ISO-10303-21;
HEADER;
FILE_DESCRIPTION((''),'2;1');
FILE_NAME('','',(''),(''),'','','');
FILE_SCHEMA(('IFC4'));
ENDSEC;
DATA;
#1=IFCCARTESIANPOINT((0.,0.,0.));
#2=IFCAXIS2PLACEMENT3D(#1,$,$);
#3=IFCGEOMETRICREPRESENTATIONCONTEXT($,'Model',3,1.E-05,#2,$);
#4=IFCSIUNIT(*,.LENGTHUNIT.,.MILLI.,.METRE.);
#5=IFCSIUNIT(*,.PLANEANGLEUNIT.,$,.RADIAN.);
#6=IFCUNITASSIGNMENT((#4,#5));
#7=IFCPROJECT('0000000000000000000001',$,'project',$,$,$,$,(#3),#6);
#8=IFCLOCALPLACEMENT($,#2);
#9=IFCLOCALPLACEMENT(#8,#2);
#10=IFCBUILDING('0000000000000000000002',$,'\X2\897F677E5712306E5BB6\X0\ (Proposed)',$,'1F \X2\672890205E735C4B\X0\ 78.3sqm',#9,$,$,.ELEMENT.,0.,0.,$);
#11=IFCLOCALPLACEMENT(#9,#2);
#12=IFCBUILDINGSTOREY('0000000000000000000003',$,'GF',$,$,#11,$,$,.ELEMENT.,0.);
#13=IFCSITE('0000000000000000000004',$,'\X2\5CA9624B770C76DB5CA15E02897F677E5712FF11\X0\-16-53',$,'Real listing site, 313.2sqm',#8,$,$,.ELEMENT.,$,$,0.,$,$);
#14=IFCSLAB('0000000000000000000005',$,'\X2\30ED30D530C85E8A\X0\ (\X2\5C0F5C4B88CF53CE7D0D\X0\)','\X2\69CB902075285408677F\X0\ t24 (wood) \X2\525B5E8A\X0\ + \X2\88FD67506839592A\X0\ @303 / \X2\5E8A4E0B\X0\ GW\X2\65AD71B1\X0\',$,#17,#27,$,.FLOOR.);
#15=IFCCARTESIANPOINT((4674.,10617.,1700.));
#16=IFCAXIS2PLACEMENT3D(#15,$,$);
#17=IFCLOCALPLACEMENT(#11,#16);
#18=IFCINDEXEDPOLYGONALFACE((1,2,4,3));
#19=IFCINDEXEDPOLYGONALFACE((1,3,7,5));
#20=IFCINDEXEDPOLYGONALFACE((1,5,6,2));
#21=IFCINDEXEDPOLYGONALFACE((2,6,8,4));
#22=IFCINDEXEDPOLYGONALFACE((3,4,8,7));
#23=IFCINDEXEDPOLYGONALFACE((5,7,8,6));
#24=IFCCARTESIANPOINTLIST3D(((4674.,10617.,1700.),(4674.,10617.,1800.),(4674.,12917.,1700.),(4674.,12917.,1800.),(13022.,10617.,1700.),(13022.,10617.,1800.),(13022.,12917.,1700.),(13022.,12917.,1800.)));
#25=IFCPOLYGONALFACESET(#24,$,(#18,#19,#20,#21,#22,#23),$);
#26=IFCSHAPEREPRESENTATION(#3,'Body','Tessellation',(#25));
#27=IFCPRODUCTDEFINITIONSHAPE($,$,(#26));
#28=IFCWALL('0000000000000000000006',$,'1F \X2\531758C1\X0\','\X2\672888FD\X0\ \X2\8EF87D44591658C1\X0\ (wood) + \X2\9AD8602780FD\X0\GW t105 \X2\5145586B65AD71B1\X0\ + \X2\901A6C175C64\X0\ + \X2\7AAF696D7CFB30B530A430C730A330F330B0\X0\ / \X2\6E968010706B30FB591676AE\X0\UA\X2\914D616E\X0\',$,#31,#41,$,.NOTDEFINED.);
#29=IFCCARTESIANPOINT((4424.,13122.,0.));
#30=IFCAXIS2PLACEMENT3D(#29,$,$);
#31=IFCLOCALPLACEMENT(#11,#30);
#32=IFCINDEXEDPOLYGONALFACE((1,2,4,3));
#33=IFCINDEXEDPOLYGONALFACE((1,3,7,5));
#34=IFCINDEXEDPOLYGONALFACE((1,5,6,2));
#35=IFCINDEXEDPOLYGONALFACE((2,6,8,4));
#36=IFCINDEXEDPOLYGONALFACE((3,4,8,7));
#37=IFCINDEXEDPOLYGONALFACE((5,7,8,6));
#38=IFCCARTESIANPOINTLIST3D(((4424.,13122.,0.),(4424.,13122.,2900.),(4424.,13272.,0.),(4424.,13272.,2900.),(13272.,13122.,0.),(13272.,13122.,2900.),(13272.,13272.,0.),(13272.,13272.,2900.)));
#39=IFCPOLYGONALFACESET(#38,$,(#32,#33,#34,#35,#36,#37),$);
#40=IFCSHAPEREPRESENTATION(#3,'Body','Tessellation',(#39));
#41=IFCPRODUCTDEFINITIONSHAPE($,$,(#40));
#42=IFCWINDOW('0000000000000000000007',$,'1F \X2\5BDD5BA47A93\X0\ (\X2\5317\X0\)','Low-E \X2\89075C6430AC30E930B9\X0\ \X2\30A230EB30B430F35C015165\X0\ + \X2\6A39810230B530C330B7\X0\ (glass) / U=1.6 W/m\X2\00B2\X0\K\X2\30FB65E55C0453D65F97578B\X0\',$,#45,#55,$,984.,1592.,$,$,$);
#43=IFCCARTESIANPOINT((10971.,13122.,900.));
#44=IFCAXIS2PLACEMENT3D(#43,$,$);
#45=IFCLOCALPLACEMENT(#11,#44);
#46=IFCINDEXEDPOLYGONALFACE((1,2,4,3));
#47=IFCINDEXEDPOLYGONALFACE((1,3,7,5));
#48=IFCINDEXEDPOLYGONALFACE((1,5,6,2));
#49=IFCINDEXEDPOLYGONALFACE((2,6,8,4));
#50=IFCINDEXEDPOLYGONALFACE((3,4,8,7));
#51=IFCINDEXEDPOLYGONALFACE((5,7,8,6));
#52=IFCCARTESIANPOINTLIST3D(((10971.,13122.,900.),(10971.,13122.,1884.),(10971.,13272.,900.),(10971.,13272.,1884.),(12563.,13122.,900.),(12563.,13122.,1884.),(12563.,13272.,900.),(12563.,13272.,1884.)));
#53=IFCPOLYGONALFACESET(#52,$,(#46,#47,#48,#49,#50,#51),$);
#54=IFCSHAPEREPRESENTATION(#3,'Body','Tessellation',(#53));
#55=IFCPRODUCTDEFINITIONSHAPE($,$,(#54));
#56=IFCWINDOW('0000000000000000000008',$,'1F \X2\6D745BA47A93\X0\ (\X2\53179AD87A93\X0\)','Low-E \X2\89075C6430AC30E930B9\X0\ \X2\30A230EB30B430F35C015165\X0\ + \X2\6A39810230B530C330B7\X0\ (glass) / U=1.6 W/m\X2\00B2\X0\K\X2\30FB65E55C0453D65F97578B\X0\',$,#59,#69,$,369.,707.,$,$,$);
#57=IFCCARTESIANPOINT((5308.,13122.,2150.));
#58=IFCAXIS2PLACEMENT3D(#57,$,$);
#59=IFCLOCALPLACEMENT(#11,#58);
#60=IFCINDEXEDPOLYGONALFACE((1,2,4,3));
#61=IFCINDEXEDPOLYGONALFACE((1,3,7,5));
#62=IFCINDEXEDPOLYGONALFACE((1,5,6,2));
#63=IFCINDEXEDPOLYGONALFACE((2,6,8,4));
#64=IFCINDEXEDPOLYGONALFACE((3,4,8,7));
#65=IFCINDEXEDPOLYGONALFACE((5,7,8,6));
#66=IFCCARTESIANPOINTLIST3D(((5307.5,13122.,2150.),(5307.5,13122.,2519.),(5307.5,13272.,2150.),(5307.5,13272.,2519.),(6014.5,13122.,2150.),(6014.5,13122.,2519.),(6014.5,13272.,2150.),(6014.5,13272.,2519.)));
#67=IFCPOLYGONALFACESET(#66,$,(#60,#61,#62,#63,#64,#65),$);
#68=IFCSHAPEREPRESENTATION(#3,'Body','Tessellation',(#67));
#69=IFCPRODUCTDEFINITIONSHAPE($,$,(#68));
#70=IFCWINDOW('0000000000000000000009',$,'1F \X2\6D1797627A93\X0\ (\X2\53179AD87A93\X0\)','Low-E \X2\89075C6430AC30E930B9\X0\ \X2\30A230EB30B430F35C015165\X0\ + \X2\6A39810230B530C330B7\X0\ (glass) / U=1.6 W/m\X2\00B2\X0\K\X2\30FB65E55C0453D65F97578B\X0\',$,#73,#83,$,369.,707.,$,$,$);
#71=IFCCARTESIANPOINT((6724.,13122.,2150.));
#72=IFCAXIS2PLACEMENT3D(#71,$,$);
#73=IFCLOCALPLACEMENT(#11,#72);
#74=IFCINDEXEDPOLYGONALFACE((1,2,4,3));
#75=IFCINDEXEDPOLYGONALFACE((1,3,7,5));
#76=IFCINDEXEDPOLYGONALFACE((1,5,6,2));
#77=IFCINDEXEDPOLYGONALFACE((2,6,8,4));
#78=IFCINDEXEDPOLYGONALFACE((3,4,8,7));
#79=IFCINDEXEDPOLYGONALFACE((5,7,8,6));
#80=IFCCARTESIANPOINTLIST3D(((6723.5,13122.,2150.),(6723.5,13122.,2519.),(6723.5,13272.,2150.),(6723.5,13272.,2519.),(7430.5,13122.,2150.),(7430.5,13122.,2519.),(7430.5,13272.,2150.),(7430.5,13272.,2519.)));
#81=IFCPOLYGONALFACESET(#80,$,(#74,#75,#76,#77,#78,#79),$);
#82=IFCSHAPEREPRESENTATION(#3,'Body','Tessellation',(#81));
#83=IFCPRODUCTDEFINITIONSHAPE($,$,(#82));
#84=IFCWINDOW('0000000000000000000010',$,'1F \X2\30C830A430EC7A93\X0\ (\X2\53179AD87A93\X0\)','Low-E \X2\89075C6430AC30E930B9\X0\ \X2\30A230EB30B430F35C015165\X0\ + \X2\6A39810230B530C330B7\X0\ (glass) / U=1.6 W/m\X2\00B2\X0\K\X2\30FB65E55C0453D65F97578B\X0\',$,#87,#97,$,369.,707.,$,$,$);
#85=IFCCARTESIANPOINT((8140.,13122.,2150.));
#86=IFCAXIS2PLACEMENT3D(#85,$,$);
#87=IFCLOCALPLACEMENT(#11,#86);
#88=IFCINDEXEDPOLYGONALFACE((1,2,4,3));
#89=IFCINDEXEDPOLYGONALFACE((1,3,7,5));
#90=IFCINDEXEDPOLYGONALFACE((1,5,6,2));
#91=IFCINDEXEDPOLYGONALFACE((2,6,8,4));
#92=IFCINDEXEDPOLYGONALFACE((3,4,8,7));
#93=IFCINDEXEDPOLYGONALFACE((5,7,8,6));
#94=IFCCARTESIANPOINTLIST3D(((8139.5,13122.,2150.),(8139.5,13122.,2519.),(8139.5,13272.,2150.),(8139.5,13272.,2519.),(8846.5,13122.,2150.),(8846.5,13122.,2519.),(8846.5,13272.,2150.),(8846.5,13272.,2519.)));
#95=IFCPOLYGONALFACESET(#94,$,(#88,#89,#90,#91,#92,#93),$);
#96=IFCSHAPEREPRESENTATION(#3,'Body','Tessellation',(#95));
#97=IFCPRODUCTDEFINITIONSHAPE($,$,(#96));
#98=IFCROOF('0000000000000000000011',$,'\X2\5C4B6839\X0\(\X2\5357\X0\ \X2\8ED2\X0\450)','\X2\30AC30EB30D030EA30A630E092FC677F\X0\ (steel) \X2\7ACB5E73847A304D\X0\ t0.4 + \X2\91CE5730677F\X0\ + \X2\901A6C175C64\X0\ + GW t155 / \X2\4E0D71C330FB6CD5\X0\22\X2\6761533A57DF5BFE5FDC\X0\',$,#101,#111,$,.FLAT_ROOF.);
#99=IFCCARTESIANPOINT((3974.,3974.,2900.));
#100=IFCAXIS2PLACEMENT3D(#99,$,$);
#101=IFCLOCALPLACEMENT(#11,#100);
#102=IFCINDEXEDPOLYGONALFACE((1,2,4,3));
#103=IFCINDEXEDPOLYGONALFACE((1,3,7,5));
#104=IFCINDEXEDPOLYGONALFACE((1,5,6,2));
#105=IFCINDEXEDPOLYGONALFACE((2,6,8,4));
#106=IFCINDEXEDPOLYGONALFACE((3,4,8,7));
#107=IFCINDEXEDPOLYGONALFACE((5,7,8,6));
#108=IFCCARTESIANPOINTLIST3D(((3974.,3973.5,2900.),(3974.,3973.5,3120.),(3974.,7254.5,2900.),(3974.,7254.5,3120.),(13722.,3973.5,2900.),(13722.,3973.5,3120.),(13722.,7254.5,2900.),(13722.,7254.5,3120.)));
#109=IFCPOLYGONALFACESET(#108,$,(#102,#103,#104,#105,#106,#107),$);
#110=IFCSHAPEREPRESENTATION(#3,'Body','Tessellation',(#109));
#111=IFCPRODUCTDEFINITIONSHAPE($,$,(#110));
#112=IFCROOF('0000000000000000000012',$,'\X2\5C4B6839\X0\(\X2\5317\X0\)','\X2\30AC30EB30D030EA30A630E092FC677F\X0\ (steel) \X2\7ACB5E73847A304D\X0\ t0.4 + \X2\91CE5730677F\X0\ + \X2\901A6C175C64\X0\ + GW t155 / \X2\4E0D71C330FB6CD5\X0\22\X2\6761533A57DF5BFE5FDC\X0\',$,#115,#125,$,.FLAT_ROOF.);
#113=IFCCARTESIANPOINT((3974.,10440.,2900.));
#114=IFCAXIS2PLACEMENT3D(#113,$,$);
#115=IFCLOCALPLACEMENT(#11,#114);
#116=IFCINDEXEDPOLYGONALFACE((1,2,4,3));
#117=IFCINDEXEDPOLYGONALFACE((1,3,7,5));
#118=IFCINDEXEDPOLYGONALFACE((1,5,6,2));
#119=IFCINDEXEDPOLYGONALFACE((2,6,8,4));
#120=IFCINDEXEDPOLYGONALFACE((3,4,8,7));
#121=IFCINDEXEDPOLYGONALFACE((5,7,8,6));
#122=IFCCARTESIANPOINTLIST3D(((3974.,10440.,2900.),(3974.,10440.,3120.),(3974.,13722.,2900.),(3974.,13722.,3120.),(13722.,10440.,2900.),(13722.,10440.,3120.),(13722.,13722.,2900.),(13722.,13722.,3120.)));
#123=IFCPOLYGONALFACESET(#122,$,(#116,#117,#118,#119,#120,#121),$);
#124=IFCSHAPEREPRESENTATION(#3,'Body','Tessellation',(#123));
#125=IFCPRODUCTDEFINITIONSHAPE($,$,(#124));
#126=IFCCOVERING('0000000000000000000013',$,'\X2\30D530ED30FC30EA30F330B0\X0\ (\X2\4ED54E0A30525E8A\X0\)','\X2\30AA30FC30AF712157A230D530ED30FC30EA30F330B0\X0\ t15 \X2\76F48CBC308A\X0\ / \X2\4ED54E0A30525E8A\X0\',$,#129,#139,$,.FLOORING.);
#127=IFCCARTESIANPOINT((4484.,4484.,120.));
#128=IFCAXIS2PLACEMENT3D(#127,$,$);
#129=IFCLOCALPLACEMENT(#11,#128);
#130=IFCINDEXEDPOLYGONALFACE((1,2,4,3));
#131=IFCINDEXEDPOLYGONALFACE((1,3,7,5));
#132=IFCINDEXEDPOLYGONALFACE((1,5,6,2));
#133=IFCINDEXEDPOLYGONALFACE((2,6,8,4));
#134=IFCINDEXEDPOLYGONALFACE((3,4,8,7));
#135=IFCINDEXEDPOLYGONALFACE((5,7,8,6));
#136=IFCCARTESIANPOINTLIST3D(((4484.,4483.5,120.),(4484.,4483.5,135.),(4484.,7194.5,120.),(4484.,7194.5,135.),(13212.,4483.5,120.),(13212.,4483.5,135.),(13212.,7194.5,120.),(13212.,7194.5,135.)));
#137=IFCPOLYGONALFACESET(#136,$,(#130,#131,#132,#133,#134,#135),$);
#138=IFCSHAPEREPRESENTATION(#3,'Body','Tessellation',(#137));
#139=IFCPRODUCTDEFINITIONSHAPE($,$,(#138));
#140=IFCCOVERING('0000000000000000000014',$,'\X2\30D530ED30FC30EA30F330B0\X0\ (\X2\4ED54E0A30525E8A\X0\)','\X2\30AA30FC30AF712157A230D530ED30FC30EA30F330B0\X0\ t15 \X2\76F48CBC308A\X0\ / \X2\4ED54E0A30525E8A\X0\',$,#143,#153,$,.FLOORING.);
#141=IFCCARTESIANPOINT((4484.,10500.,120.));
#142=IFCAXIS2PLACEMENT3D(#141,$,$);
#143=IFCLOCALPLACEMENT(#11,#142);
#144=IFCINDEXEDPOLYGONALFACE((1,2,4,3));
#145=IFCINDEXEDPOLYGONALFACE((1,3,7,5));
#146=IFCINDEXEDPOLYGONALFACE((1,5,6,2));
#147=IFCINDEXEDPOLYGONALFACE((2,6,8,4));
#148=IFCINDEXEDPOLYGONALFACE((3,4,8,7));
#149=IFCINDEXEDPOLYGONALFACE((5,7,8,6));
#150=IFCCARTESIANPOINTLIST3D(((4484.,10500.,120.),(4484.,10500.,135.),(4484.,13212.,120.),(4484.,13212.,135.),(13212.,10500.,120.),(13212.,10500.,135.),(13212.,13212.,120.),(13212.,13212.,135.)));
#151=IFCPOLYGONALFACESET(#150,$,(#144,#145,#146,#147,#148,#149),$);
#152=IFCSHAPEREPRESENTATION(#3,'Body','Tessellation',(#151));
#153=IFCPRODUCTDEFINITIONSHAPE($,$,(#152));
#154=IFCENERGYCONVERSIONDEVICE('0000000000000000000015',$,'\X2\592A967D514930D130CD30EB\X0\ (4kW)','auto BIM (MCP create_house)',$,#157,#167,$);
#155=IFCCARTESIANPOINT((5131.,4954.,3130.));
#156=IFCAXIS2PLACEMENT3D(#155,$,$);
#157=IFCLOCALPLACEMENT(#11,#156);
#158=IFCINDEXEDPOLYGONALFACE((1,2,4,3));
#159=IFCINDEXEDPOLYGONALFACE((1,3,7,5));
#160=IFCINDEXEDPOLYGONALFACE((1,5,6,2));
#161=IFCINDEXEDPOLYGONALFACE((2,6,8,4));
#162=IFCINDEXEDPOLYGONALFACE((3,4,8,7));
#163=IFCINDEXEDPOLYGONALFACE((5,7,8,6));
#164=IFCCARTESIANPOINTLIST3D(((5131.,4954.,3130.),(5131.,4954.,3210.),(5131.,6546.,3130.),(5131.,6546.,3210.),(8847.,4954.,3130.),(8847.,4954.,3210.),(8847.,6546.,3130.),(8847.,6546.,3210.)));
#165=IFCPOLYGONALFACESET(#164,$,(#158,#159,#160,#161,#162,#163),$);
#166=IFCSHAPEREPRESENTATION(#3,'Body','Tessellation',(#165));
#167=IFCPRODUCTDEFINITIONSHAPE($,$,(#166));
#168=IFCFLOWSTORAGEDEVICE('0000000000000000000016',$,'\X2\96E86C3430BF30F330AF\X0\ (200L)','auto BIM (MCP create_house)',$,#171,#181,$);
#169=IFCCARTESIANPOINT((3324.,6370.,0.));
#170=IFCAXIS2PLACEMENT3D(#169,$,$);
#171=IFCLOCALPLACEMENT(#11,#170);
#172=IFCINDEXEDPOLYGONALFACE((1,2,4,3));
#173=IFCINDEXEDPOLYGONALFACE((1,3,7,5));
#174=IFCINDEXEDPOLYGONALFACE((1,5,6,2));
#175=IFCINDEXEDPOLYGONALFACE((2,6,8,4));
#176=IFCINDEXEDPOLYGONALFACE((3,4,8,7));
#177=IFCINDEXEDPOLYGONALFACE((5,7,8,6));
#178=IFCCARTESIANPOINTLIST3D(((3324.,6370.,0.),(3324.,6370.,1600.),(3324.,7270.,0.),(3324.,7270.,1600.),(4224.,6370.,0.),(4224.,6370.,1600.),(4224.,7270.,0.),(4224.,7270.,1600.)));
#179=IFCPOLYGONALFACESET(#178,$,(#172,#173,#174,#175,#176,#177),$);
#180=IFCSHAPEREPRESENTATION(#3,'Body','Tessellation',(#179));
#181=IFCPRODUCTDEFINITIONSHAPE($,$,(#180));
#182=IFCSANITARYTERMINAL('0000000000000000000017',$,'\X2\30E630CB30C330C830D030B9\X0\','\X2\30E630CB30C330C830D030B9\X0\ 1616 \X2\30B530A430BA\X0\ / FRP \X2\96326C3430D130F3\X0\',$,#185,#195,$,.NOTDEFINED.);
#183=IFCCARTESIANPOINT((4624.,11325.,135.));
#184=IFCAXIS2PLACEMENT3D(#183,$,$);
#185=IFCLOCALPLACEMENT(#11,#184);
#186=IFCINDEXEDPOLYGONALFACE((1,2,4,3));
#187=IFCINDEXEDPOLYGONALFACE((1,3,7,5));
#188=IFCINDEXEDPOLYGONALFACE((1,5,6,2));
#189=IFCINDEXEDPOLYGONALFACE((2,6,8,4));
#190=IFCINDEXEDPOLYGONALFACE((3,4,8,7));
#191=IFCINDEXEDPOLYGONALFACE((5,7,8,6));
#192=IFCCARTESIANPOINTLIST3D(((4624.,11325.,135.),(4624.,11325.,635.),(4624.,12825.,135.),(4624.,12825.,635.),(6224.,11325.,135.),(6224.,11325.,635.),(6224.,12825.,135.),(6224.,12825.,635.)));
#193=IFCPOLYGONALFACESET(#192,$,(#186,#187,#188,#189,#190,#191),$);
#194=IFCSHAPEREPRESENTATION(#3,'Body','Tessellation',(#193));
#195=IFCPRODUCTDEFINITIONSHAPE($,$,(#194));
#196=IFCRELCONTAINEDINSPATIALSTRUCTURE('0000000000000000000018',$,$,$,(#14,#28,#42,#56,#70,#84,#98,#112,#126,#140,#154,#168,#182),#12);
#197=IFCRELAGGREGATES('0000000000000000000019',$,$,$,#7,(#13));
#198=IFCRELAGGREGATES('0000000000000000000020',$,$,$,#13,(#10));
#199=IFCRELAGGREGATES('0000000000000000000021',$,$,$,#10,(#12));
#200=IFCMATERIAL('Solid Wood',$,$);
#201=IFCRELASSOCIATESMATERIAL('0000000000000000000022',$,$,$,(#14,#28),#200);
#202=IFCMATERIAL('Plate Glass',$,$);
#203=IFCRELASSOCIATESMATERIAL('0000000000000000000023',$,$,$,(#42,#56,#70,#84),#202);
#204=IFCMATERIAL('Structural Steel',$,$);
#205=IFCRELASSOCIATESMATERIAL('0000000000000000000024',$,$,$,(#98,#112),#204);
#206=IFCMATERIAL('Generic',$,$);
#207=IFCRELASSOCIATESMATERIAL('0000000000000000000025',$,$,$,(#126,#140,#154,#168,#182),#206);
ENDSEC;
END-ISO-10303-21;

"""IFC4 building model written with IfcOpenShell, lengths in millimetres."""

from ifc_helpers import new_model, si_unit, frame, frame_2d, origin, place, context, project, spatial, rectangle, extrude, material, element, fill, save


model = new_model("IFC4")

# Units and contexts
model_context = context("Model", 3, precision=1e-05, world=origin())
ifc_project = project(units=[si_unit("LENGTHUNIT", "METRE", prefix="MILLI"), si_unit("PLANEANGLEUNIT", "RADIAN")], contexts=[model_context])

# Site, building, storey
site_placement = place(None, origin())
site = spatial("IfcSite", under=ifc_project, at=site_placement, Name="岩手県盛岡市西松園１-16-53", ObjectType="Real listing site, 313.2sqm", CompositionType="ELEMENT", RefElevation=0.0)
building_placement = place(site_placement, origin())
building = spatial("IfcBuilding", under=site, at=building_placement, Name="西松園の家 (Proposed)", ObjectType="1F 木造平屋 78.3sqm", CompositionType="ELEMENT", ElevationOfRefHeight=0.0, ElevationOfTerrain=0.0)
storey_placement = place(building_placement, origin())
storey = spatial("IfcBuildingStorey", under=building, at=storey_placement, Name="GF", CompositionType="ELEMENT", Elevation=0.0)

# Slab
ifc_material_1 = material(Name="Solid Wood")
slab_1_placement = place(storey_placement, frame((4674.0, 10617.0, 1700.0)))
element("IfcSlab", 1, at=slab_1_placement, inside=storey, material=ifc_material_1, Name="ロフト床 (小屋裏収納)", Description="構造用合板 t24 (wood) 剛床 + 製材根太 @303 / 床下 GW断熱", PredefinedType="FLOOR", context=model_context, shape_type="SweptSolid", body=[
    extrude(rectangle(XDim=8348.0, YDim=2300.0, at=frame_2d((4174.0, 1150.0))), frame((4674.0, 10617.0, 1700.0)), (0.0, 0.0, 1.0), 100.0),
])

# Shared definitions
ifc_material_2 = material(Name="Plate Glass")

# Wall, openings, windows
wall_1_placement = place(storey_placement, frame((4424.0, 13122.0, 0.0)))
wall_1 = element("IfcWall", 2, at=wall_1_placement, inside=storey, material=ifc_material_1, Name="1F 北壁", Description="木製 軸組外壁 (wood) + 高性能GW t105 充填断熱 + 通気層 + 窯業系サイディング / 準耐火・外皮UA配慮", PredefinedType="NOTDEFINED", context=model_context, shape_type="SweptSolid", body=[
    extrude(rectangle(XDim=8848.0, YDim=150.0, at=frame_2d((4424.0, 75.0))), frame((4424.0, 13122.0, 0.0)), (0.0, 0.0, 1.0), 2900.0),
])
opening_1_placement = place(storey_placement, frame((10971.0, 13122.0, 900.0)))
opening_1 = element("IfcOpeningElement", 3, at=opening_1_placement, cuts=wall_1, PredefinedType="NOTDEFINED", context=model_context, shape_type="SweptSolid", body=[
    extrude(rectangle(XDim=1592.0, YDim=150.0, at=frame_2d((796.0, 75.0))), frame((10971.0, 13122.0, 900.0)), (0.0, 0.0, 1.0), 984.0),
])
opening_2_placement = place(storey_placement, frame((5308.0, 13122.0, 2150.0)))
opening_2 = element("IfcOpeningElement", 4, at=opening_2_placement, cuts=wall_1, PredefinedType="NOTDEFINED", context=model_context, shape_type="SweptSolid", body=[
    extrude(rectangle(XDim=707.0, YDim=150.0, at=frame_2d((353.0, 75.0))), frame((5308.0, 13122.0, 2150.0)), (0.0, 0.0, 1.0), 369.0),
])
opening_3_placement = place(storey_placement, frame((6724.0, 13122.0, 2150.0)))
opening_3 = element("IfcOpeningElement", 5, at=opening_3_placement, cuts=wall_1, PredefinedType="NOTDEFINED", context=model_context, shape_type="SweptSolid", body=[
    extrude(rectangle(XDim=707.0, YDim=150.0, at=frame_2d((353.0, 75.0))), frame((6724.0, 13122.0, 2150.0)), (0.0, 0.0, 1.0), 369.0),
])
opening_4_placement = place(storey_placement, frame((8140.0, 13122.0, 2150.0)))
opening_4 = element("IfcOpeningElement", 6, at=opening_4_placement, cuts=wall_1, PredefinedType="NOTDEFINED", context=model_context, shape_type="SweptSolid", body=[
    extrude(rectangle(XDim=707.0, YDim=150.0, at=frame_2d((353.0, 75.0))), frame((8140.0, 13122.0, 2150.0)), (0.0, 0.0, 1.0), 369.0),
])
window_1_placement = place(storey_placement, frame((10971.0, 13122.0, 900.0)))
window_1 = element("IfcWindow", 7, at=window_1_placement, inside=storey, material=ifc_material_2, Name="1F 寝室窓 (北)", Description="Low-E 複層ガラス アルゴン封入 + 樹脂サッシ (glass) / U=1.6 W/m²K・日射取得型", OverallHeight=984.0, OverallWidth=1592.0, context=model_context, shape_type="SweptSolid", body=[
    extrude(rectangle(XDim=1592.0, YDim=150.0, at=frame_2d((796.0, 75.0))), frame((10971.0, 13122.0, 900.0)), (0.0, 0.0, 1.0), 984.0),
])
fill(opening_1, window_1)
window_2_placement = place(storey_placement, frame((5308.0, 13122.0, 2150.0)))
window_2 = element("IfcWindow", 8, at=window_2_placement, inside=storey, material=ifc_material_2, Name="1F 浴室窓 (北高窓)", Description="Low-E 複層ガラス アルゴン封入 + 樹脂サッシ (glass) / U=1.6 W/m²K・日射取得型", OverallHeight=369.0, OverallWidth=707.0, context=model_context, shape_type="SweptSolid", body=[
    extrude(rectangle(XDim=707.0, YDim=150.0, at=frame_2d((353.0, 75.0))), frame((5308.0, 13122.0, 2150.0)), (0.0, 0.0, 1.0), 369.0),
])
fill(opening_2, window_2)
window_3_placement = place(storey_placement, frame((6724.0, 13122.0, 2150.0)))
window_3 = element("IfcWindow", 9, at=window_3_placement, inside=storey, material=ifc_material_2, Name="1F 洗面窓 (北高窓)", Description="Low-E 複層ガラス アルゴン封入 + 樹脂サッシ (glass) / U=1.6 W/m²K・日射取得型", OverallHeight=369.0, OverallWidth=707.0, context=model_context, shape_type="SweptSolid", body=[
    extrude(rectangle(XDim=707.0, YDim=150.0, at=frame_2d((353.0, 75.0))), frame((6724.0, 13122.0, 2150.0)), (0.0, 0.0, 1.0), 369.0),
])
fill(opening_3, window_3)
window_4_placement = place(storey_placement, frame((8140.0, 13122.0, 2150.0)))
window_4 = element("IfcWindow", 10, at=window_4_placement, inside=storey, material=ifc_material_2, Name="1F トイレ窓 (北高窓)", Description="Low-E 複層ガラス アルゴン封入 + 樹脂サッシ (glass) / U=1.6 W/m²K・日射取得型", OverallHeight=369.0, OverallWidth=707.0, context=model_context, shape_type="SweptSolid", body=[
    extrude(rectangle(XDim=707.0, YDim=150.0, at=frame_2d((353.0, 75.0))), frame((8140.0, 13122.0, 2150.0)), (0.0, 0.0, 1.0), 369.0),
])
fill(opening_4, window_4)

# Roofs
ifc_material_3 = material(Name="Structural Steel")
roof_1_placement = place(storey_placement, frame((3974.0, 3974.0, 2900.0)))
element("IfcRoof", 11, at=roof_1_placement, inside=storey, material=ifc_material_3, Name="屋根(南 軒450)", Description="ガルバリウム鋼板 (steel) 立平葺き t0.4 + 野地板 + 通気層 + GW t155 / 不燃・法22条区域対応", PredefinedType="FLAT_ROOF", context=model_context, shape_type="SweptSolid", body=[
    extrude(rectangle(XDim=9748.0, YDim=3281.0, at=frame_2d((4874.0, 1640.0))), frame((3974.0, 3974.0, 2900.0)), (0.0, 0.0, 1.0), 220.0),
])
roof_2_placement = place(storey_placement, frame((3974.0, 10440.0, 2900.0)))
element("IfcRoof", 12, at=roof_2_placement, inside=storey, material=ifc_material_3, Name="屋根(北)", Description="ガルバリウム鋼板 (steel) 立平葺き t0.4 + 野地板 + 通気層 + GW t155 / 不燃・法22条区域対応", PredefinedType="FLAT_ROOF", context=model_context, shape_type="SweptSolid", body=[
    extrude(rectangle(XDim=9748.0, YDim=3282.0, at=frame_2d((4874.0, 1641.0))), frame((3974.0, 10440.0, 2900.0)), (0.0, 0.0, 1.0), 220.0),
])

# Coverings
ifc_material_4 = material(Name="Generic")
covering_1_placement = place(storey_placement, frame((4484.0, 4484.0, 120.0)))
element("IfcCovering", 13, at=covering_1_placement, inside=storey, material=ifc_material_4, Name="フローリング (仕上げ床)", Description="オーク無垢フローリング t15 直貼り / 仕上げ床", PredefinedType="FLOORING", context=model_context, shape_type="SweptSolid", body=[
    extrude(rectangle(XDim=8728.0, YDim=2711.0, at=frame_2d((4364.0, 1355.0))), frame((4484.0, 4484.0, 120.0)), (0.0, 0.0, 1.0), 15.0),
])
covering_2_placement = place(storey_placement, frame((4484.0, 10500.0, 120.0)))
element("IfcCovering", 14, at=covering_2_placement, inside=storey, material=ifc_material_4, Name="フローリング (仕上げ床)", Description="オーク無垢フローリング t15 直貼り / 仕上げ床", PredefinedType="FLOORING", context=model_context, shape_type="SweptSolid", body=[
    extrude(rectangle(XDim=8728.0, YDim=2712.0, at=frame_2d((4364.0, 1356.0))), frame((4484.0, 10500.0, 120.0)), (0.0, 0.0, 1.0), 15.0),
])

# Energy conversion device
energy_conversion_device_placement = place(storey_placement, frame((5131.0, 4954.0, 3130.0)))
element("IfcEnergyConversionDevice", 15, at=energy_conversion_device_placement, inside=storey, material=ifc_material_4, Name="太陽光パネル (4kW)", Description="auto BIM (MCP create_house)", context=model_context, shape_type="SweptSolid", body=[
    extrude(rectangle(XDim=3716.0, YDim=1592.0, at=frame_2d((1858.0, 796.0))), frame((5131.0, 4954.0, 3130.0)), (0.0, 0.0, 1.0), 80.0),
])

# Flow storage device
flow_storage_device_placement = place(storey_placement, frame((3324.0, 6370.0, 0.0)))
element("IfcFlowStorageDevice", 16, at=flow_storage_device_placement, inside=storey, material=ifc_material_4, Name="雨水タンク (200L)", Description="auto BIM (MCP create_house)", context=model_context, shape_type="SweptSolid", body=[
    extrude(rectangle(XDim=900.0, YDim=900.0, at=frame_2d((450.0, 450.0))), frame((3324.0, 6370.0, 0.0)), (0.0, 0.0, 1.0), 1600.0),
])

# Sanitary terminal
sanitary_terminal_placement = place(storey_placement, frame((4624.0, 11325.0, 135.0)))
element("IfcSanitaryTerminal", 17, at=sanitary_terminal_placement, inside=storey, material=ifc_material_4, Name="ユニットバス", Description="ユニットバス 1616 サイズ / FRP 防水パン", PredefinedType="NOTDEFINED", context=model_context, shape_type="SweptSolid", body=[
    extrude(rectangle(XDim=1600.0, YDim=1500.0, at=frame_2d((800.0, 750.0))), frame((4624.0, 11325.0, 135.0)), (0.0, 0.0, 1.0), 500.0),
])

save(model, "model.ifc")
